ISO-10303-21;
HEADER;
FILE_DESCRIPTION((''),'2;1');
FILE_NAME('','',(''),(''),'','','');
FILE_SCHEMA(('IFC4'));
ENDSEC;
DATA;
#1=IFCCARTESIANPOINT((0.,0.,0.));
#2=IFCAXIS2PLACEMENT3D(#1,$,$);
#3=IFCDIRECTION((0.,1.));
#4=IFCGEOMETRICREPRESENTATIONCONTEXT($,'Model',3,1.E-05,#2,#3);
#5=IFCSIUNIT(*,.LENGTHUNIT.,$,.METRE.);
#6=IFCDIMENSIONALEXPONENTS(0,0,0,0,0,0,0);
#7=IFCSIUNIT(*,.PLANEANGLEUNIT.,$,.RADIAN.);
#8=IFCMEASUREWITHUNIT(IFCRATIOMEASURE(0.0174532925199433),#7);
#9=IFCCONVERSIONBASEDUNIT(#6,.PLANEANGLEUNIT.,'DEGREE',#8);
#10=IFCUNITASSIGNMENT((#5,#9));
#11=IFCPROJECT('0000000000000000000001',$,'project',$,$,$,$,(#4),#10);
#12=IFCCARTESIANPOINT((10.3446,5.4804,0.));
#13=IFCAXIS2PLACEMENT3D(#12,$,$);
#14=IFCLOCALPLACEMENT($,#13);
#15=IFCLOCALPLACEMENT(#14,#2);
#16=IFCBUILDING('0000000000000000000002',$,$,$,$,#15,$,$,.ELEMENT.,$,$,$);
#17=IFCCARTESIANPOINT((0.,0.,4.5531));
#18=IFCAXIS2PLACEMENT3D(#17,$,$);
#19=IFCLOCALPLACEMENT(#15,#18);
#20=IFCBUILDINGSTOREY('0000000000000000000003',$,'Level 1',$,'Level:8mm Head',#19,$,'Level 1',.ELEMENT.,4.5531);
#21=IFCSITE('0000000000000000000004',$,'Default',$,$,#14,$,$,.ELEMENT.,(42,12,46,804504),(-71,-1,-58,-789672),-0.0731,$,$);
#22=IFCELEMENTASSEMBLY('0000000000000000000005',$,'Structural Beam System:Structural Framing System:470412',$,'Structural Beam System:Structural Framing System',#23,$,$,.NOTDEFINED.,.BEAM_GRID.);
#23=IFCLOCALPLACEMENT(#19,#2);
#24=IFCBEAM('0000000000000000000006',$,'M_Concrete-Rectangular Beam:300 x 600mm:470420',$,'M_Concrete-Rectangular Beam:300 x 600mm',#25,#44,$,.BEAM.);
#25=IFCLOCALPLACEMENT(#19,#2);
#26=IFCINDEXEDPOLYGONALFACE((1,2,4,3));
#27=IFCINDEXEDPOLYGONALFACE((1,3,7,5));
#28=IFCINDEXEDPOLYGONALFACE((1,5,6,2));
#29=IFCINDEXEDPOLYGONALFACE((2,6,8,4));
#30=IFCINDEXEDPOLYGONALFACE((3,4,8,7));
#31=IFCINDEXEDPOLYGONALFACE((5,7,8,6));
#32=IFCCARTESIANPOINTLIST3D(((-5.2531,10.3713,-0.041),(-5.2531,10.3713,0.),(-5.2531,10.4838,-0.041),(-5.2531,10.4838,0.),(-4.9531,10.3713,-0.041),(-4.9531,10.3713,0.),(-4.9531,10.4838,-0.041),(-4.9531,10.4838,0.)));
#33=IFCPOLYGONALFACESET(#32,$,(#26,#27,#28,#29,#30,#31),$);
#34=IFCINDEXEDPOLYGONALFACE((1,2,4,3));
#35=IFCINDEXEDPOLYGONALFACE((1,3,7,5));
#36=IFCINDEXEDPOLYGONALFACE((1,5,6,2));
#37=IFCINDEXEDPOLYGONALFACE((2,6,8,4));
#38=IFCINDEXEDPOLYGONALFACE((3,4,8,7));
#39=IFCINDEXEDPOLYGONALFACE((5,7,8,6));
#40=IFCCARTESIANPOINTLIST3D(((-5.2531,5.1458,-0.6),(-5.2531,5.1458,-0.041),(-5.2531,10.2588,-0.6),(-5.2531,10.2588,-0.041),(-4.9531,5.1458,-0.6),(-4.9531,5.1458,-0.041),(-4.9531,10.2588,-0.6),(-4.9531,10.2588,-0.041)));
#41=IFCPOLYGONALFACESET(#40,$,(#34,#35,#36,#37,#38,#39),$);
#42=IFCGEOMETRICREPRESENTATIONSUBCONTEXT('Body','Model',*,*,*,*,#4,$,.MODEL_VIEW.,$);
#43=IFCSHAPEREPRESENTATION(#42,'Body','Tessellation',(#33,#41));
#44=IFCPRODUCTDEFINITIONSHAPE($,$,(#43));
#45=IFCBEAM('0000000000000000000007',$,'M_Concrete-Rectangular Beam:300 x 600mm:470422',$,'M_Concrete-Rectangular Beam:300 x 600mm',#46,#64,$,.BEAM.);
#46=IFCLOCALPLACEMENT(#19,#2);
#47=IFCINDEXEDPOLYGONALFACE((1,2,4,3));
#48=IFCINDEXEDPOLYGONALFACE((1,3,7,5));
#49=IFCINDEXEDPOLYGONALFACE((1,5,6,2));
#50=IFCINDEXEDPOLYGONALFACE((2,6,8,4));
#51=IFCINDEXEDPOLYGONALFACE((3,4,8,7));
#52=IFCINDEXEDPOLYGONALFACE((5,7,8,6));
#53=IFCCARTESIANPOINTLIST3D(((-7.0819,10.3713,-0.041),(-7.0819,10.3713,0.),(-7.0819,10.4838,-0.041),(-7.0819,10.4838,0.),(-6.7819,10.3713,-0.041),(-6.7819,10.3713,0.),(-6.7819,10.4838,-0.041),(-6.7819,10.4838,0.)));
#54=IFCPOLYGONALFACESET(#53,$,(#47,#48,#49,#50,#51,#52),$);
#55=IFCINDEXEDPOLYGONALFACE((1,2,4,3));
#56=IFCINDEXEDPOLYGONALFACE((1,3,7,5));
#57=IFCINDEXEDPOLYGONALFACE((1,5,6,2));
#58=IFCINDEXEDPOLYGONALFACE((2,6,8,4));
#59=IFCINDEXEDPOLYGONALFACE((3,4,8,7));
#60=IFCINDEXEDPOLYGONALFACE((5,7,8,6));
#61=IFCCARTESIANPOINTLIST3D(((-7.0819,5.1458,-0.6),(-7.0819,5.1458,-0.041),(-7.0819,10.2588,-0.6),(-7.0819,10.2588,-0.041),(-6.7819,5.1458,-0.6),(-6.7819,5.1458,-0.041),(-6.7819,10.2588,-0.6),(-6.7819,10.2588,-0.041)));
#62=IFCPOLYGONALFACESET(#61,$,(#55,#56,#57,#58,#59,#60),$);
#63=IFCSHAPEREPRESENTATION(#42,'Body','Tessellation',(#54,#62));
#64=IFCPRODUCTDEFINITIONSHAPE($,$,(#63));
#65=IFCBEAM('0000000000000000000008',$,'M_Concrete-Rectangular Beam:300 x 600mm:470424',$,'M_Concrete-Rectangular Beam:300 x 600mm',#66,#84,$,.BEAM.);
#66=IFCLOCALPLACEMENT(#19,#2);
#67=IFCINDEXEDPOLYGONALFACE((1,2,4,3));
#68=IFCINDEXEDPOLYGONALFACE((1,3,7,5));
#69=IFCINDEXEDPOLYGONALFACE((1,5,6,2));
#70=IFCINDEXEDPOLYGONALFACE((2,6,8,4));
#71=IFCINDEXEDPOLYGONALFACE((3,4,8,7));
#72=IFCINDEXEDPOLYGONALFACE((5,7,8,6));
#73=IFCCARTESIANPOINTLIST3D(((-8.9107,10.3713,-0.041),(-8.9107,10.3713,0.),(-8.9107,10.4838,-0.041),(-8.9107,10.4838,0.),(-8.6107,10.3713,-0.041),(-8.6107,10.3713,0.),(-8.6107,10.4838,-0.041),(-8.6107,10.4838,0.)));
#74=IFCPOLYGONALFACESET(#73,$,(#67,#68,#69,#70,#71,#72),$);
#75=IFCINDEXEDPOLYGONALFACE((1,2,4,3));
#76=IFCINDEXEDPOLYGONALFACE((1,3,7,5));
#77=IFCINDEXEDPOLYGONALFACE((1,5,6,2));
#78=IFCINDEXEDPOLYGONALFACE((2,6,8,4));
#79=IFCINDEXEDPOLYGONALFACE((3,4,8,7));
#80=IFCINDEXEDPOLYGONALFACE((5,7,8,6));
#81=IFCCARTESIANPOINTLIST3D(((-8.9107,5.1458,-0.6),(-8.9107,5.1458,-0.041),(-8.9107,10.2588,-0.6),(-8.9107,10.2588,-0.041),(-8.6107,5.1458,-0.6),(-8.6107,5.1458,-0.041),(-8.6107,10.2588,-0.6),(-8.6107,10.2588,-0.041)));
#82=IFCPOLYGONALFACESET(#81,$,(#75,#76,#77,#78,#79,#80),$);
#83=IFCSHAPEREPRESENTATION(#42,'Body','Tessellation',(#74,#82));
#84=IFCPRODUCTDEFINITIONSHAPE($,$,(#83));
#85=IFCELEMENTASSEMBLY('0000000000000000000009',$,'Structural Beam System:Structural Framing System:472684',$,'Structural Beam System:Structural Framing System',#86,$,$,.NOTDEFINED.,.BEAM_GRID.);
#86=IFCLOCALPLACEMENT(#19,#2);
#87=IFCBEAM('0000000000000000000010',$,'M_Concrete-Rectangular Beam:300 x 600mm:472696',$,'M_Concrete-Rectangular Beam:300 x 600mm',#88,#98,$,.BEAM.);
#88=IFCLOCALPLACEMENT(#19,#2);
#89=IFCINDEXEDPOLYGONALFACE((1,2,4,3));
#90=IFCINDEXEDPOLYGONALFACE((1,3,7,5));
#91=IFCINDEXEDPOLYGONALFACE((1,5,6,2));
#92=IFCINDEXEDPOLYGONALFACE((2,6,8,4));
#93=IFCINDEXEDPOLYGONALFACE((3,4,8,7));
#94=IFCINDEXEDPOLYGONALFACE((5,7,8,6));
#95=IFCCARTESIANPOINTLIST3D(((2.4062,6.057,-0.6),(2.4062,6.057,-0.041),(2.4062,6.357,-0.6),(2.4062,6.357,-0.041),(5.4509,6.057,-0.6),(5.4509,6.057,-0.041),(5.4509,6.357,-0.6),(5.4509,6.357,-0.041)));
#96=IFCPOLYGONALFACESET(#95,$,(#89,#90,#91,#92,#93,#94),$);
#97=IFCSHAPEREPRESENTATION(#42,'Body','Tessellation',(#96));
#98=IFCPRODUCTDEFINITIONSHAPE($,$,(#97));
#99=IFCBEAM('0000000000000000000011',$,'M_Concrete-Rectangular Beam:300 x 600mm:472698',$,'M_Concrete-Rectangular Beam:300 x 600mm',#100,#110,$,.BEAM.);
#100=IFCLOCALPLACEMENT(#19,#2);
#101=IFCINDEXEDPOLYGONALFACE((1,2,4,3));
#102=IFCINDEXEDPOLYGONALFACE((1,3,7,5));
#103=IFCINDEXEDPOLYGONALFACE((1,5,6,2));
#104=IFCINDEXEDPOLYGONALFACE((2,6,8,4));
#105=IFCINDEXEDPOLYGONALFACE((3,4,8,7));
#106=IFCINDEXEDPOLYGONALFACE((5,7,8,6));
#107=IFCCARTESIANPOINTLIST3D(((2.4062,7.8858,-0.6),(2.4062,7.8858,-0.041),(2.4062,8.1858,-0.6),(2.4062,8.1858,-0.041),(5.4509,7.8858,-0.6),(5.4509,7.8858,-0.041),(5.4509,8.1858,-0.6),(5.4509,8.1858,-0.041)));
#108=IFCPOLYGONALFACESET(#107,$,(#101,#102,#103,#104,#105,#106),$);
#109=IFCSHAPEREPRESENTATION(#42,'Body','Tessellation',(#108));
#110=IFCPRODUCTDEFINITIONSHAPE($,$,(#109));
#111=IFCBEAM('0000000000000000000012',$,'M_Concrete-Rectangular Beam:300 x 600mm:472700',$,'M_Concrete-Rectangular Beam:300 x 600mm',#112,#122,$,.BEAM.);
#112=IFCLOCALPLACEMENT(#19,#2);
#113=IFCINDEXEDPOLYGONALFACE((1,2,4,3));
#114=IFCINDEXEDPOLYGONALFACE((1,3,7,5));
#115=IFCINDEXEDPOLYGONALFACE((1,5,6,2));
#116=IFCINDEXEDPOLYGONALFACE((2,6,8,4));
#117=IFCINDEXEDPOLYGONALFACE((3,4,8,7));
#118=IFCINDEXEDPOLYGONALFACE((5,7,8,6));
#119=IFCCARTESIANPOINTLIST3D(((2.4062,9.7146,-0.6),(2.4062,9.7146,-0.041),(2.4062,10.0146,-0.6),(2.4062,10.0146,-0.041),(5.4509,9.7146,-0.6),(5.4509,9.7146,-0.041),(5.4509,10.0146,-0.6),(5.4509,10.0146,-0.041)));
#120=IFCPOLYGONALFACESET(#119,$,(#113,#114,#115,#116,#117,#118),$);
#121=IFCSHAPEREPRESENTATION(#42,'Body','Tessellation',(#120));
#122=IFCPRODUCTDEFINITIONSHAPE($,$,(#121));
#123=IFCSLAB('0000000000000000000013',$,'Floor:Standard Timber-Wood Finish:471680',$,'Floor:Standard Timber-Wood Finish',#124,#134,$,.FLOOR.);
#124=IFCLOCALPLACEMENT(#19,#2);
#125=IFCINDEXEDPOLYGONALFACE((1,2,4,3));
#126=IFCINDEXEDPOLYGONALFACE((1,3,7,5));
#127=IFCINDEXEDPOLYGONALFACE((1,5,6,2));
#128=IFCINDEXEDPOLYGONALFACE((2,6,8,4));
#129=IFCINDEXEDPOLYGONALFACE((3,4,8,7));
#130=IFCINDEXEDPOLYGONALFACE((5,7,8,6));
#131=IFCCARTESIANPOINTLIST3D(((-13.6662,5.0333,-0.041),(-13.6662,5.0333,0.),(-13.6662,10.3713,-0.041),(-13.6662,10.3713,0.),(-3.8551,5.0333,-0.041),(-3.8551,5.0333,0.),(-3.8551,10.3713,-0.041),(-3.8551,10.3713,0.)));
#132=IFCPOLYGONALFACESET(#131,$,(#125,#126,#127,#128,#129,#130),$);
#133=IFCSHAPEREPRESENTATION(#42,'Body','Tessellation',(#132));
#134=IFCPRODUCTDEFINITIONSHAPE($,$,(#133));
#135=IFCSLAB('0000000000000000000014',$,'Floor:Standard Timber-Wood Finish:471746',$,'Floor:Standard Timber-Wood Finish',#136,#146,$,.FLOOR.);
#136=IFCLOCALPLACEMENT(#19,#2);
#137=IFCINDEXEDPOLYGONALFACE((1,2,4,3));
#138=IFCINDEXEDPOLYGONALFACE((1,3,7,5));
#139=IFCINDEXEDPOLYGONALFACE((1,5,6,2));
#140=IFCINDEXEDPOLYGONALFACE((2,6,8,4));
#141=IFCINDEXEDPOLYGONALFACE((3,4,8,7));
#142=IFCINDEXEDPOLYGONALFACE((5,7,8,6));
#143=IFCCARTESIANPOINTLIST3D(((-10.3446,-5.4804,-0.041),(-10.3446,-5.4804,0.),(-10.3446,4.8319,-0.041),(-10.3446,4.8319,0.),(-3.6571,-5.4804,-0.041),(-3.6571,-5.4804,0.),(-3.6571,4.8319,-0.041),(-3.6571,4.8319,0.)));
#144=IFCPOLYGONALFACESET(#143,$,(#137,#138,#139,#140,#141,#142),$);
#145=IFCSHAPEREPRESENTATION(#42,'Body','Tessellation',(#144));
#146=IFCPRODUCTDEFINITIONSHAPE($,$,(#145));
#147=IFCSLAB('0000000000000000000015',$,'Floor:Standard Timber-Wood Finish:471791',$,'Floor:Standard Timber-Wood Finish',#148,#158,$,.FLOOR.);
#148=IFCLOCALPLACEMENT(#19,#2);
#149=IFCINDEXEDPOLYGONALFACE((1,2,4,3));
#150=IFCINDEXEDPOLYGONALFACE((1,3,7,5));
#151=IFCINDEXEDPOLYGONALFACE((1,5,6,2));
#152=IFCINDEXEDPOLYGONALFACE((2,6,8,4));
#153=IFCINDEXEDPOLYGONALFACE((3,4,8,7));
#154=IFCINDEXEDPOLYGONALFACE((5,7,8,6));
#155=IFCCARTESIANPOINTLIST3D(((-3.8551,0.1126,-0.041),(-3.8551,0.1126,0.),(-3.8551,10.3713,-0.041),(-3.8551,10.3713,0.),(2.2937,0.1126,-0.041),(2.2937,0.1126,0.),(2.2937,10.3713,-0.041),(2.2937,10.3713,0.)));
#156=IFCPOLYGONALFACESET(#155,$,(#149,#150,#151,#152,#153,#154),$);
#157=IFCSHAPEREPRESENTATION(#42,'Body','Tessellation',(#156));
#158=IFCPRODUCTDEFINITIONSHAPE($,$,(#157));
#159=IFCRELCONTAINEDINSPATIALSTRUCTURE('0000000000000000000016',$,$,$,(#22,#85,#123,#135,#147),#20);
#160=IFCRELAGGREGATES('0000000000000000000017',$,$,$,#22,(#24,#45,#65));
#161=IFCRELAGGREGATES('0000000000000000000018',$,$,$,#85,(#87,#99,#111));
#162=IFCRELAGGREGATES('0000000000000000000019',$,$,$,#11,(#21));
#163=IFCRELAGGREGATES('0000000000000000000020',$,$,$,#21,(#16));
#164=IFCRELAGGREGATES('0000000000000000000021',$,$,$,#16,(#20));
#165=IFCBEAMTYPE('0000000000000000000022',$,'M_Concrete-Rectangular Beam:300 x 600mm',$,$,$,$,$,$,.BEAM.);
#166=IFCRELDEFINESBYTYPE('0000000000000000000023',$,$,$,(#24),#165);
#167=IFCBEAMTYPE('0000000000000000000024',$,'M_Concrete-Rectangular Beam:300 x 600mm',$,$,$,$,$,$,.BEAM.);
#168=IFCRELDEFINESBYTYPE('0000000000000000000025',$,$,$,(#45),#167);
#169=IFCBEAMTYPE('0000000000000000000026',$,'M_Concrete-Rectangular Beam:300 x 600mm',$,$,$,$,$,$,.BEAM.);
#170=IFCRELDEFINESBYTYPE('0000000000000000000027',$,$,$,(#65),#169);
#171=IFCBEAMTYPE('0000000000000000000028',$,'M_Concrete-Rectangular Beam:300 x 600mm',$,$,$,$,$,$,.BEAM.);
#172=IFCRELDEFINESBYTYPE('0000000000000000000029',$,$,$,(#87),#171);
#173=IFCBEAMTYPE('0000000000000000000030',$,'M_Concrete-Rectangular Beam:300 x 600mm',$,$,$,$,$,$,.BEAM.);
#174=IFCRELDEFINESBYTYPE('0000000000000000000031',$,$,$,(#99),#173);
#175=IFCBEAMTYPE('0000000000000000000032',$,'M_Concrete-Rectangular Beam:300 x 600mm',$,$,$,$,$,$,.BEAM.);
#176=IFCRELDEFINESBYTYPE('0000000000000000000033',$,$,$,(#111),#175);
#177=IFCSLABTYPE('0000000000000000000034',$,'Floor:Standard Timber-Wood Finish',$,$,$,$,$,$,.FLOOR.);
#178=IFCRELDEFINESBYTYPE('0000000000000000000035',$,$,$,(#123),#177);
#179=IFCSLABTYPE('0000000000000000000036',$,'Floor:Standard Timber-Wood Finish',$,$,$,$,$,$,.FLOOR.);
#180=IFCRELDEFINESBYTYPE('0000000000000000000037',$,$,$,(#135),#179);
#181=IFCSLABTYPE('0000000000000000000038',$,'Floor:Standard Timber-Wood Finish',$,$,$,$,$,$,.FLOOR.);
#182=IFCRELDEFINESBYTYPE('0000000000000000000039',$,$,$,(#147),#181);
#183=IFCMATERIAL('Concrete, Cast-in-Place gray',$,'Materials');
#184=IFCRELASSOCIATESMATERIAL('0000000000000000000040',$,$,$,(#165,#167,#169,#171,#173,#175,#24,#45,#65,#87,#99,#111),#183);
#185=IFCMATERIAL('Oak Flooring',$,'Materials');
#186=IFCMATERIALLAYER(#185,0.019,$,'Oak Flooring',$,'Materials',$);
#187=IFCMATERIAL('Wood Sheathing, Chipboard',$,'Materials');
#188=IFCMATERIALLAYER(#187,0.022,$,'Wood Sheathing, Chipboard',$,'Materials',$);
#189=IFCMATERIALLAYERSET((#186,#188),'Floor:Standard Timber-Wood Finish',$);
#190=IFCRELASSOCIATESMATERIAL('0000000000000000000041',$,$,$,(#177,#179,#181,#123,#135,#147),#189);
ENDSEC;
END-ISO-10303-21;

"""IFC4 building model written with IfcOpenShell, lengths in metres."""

from ifc_helpers import new_model, entity, si_unit, converted_unit, direction, frame, frame_2d, origin, origin_2d_with_axis, place, context, subcontext, project, spatial, rectangle, extrude, source, transform, mapped, material, layer, layer_set, layer_usage, material_profile, profile_set, profile_usage, type_object, type_shapes, element, aggregate, save


model = new_model("IFC4")

# Units and contexts
model_context = context("Model", 3, precision=1e-05, world=origin(), true_north=direction((0.0, 1.0)))
body_context = subcontext(model_context, "Body", "Model", "MODEL_VIEW")
ifc_project = project(units=[si_unit("LENGTHUNIT", "METRE"), converted_unit("PLANEANGLEUNIT", "DEGREE", entity("IfcRatioMeasure", 0.0174532925199433), si_unit("PLANEANGLEUNIT", "RADIAN"), dimensions=[0, 0, 0, 0, 0, 0, 0])], contexts=[model_context])

# Site, building, storey
site_placement = place(None, frame((10.3446, 5.4804, 0.0)))
site = spatial("IfcSite", under=ifc_project, at=site_placement, Name="Default", CompositionType="ELEMENT", RefLatitude=(42, 12, 46, 804504), RefLongitude=(-71, -1, -58, -789672), RefElevation=-0.0731)
building_placement = place(site_placement, origin())
building = spatial("IfcBuilding", under=site, at=building_placement, CompositionType="ELEMENT")
storey_placement = place(building_placement, frame((0.0, 0.0, 4.5531)))
storey = spatial("IfcBuildingStorey", under=building, at=storey_placement, Name="Level 1", ObjectType="Level:8mm Head", LongName="Level 1", CompositionType="ELEMENT", Elevation=4.5531)

# Element assemblies, beams
assembly_1_placement = place(storey_placement, origin())
assembly_1 = element("IfcElementAssembly", 1, at=assembly_1_placement, inside=storey, Name="Structural Beam System:Structural Framing System:470412", ObjectType="Structural Beam System:Structural Framing System", AssemblyPlace="NOTDEFINED", PredefinedType="BEAM_GRID")
ifc_material_1 = material(Name="Concrete, Cast-in-Place gray", Category="Materials")
ifc_material_profile = material_profile(ifc_material_1, rectangle(XDim=0.559, YDim=0.3, at=frame_2d((0.0, 0.0), x_axis=(1.0, 0.0))), Name="300 x 600mm")
ifc_profile_set = profile_set([ifc_material_profile], Name="300 x 600mm")
ifc_profile_usage_1 = profile_usage(ifc_profile_set, cardinal=8)
beam_type_1 = type_object("IfcBeamType", Name="M_Concrete-Rectangular Beam:300 x 600mm", PredefinedType="BEAM", material=ifc_profile_set)
shared_shape_1 = source(origin(), body_context, "Body", "SweptSolid", [
    extrude(rectangle(XDim=0.041, YDim=0.3, at=frame_2d((0.0, 0.0), x_axis=(0.0, 1.0))), frame((-5.1031, 10.4838, 4.5326), z_axis=(0.0, -1.0, 0.0), x_axis=(-1.0, 0.0, 0.0)), (0.0, 0.0, 1.0), 0.1125),
    extrude(rectangle(XDim=0.559, YDim=0.3, at=frame_2d((0.0, 0.0), x_axis=(0.0, 1.0))), frame((-5.1031, 10.2588, 4.2326), z_axis=(0.0, -1.0, 0.0), x_axis=(-1.0, 0.0, 0.0)), (0.0, 0.0, 1.0), 5.113),
])
type_shapes(beam_type_1, [shared_shape_1])
beam_1_placement = place(assembly_1_placement, frame((0.0, 0.0, -4.5531)))
beam_1 = element("IfcBeam", 2, at=beam_1_placement, type_object=beam_type_1, material=ifc_profile_usage_1, Name="M_Concrete-Rectangular Beam:300 x 600mm:470420", ObjectType="M_Concrete-Rectangular Beam:300 x 600mm", PredefinedType="BEAM", context=body_context, shape_type="MappedRepresentation", body=[
    mapped(shared_shape_1, transform((0.0, 0.0, 0.0), scale=1.0)),
])
ifc_profile_usage_2 = profile_usage(ifc_profile_set, cardinal=8)
beam_type_2 = type_object("IfcBeamType", Name="M_Concrete-Rectangular Beam:300 x 600mm", PredefinedType="BEAM", material=ifc_profile_set)
shared_shape_2 = source(origin(), body_context, "Body", "SweptSolid", [
    extrude(rectangle(XDim=0.041, YDim=0.3, at=frame_2d((0.0, 0.0), x_axis=(0.0, 1.0))), frame((-6.9319, 10.4838, 4.5326), z_axis=(0.0, -1.0, 0.0), x_axis=(-1.0, 0.0, 0.0)), (0.0, 0.0, 1.0), 0.1125),
    extrude(rectangle(XDim=0.559, YDim=0.3, at=frame_2d((0.0, 0.0), x_axis=(0.0, 1.0))), frame((-6.9319, 10.2588, 4.2326), z_axis=(0.0, -1.0, 0.0), x_axis=(-1.0, 0.0, 0.0)), (0.0, 0.0, 1.0), 5.113),
])
type_shapes(beam_type_2, [shared_shape_2])
beam_2_placement = place(assembly_1_placement, frame((0.0, 0.0, -4.5531)))
beam_2 = element("IfcBeam", 3, at=beam_2_placement, type_object=beam_type_2, material=ifc_profile_usage_2, Name="M_Concrete-Rectangular Beam:300 x 600mm:470422", ObjectType="M_Concrete-Rectangular Beam:300 x 600mm", PredefinedType="BEAM", context=body_context, shape_type="MappedRepresentation", body=[
    mapped(shared_shape_2, transform((0.0, 0.0, 0.0), scale=1.0)),
])
ifc_profile_usage_3 = profile_usage(ifc_profile_set, cardinal=8)
beam_type_3 = type_object("IfcBeamType", Name="M_Concrete-Rectangular Beam:300 x 600mm", PredefinedType="BEAM", material=ifc_profile_set)
shared_shape_3 = source(origin(), body_context, "Body", "SweptSolid", [
    extrude(rectangle(XDim=0.041, YDim=0.3, at=frame_2d((0.0, 0.0), x_axis=(0.0, 1.0))), frame((-8.7607, 10.4838, 4.5326), z_axis=(0.0, -1.0, 0.0), x_axis=(-1.0, 0.0, 0.0)), (0.0, 0.0, 1.0), 0.1125),
    extrude(rectangle(XDim=0.559, YDim=0.3, at=frame_2d((0.0, 0.0), x_axis=(0.0, 1.0))), frame((-8.7607, 10.2588, 4.2326), z_axis=(0.0, -1.0, 0.0), x_axis=(-1.0, 0.0, 0.0)), (0.0, 0.0, 1.0), 5.113),
])
type_shapes(beam_type_3, [shared_shape_3])
beam_3_placement = place(assembly_1_placement, frame((0.0, 0.0, -4.5531)))
beam_3 = element("IfcBeam", 4, at=beam_3_placement, type_object=beam_type_3, material=ifc_profile_usage_3, Name="M_Concrete-Rectangular Beam:300 x 600mm:470424", ObjectType="M_Concrete-Rectangular Beam:300 x 600mm", PredefinedType="BEAM", context=body_context, shape_type="MappedRepresentation", body=[
    mapped(shared_shape_3, transform((0.0, 0.0, 0.0), scale=1.0)),
])
aggregate(assembly_1, [beam_1, beam_2, beam_3])
assembly_2_placement = place(storey_placement, origin())
assembly_2 = element("IfcElementAssembly", 5, at=assembly_2_placement, inside=storey, Name="Structural Beam System:Structural Framing System:472684", ObjectType="Structural Beam System:Structural Framing System", AssemblyPlace="NOTDEFINED", PredefinedType="BEAM_GRID")
ifc_profile_usage_4 = profile_usage(ifc_profile_set, cardinal=8)
beam_type_4 = type_object("IfcBeamType", Name="M_Concrete-Rectangular Beam:300 x 600mm", PredefinedType="BEAM", material=ifc_profile_set)
shared_shape_4 = source(origin(), body_context, "Body", "SweptSolid", [
    extrude(rectangle(XDim=0.559, YDim=0.3, at=frame_2d((0.0, 0.0), x_axis=(1.0, 0.0))), frame((5.4509, 6.207, 4.2326), z_axis=(-1.0, 0.0, 0.0), x_axis=(0.0, 0.0, -1.0)), (0.0, 0.0, 1.0), 3.0447),
])
type_shapes(beam_type_4, [shared_shape_4])
beam_4_placement = place(assembly_2_placement, frame((0.0, 0.0, -4.5531)))
beam_4 = element("IfcBeam", 6, at=beam_4_placement, type_object=beam_type_4, material=ifc_profile_usage_4, Name="M_Concrete-Rectangular Beam:300 x 600mm:472696", ObjectType="M_Concrete-Rectangular Beam:300 x 600mm", PredefinedType="BEAM", context=body_context, shape_type="MappedRepresentation", body=[
    mapped(shared_shape_4, transform((0.0, 0.0, 0.0), scale=1.0)),
])
ifc_profile_usage_5 = profile_usage(ifc_profile_set, cardinal=8)
beam_type_5 = type_object("IfcBeamType", Name="M_Concrete-Rectangular Beam:300 x 600mm", PredefinedType="BEAM", material=ifc_profile_set)
shared_shape_5 = source(origin(), body_context, "Body", "SweptSolid", [
    extrude(rectangle(XDim=0.559, YDim=0.3, at=frame_2d((0.0, 0.0), x_axis=(1.0, 0.0))), frame((5.4509, 8.0358, 4.2326), z_axis=(-1.0, 0.0, 0.0), x_axis=(0.0, 0.0, -1.0)), (0.0, 0.0, 1.0), 3.0447),
])
type_shapes(beam_type_5, [shared_shape_5])
beam_5_placement = place(assembly_2_placement, frame((0.0, 0.0, -4.5531)))
beam_5 = element("IfcBeam", 7, at=beam_5_placement, type_object=beam_type_5, material=ifc_profile_usage_5, Name="M_Concrete-Rectangular Beam:300 x 600mm:472698", ObjectType="M_Concrete-Rectangular Beam:300 x 600mm", PredefinedType="BEAM", context=body_context, shape_type="MappedRepresentation", body=[
    mapped(shared_shape_5, transform((0.0, 0.0, 0.0), scale=1.0)),
])
ifc_profile_usage_6 = profile_usage(ifc_profile_set, cardinal=8)
beam_type_6 = type_object("IfcBeamType", Name="M_Concrete-Rectangular Beam:300 x 600mm", PredefinedType="BEAM", material=ifc_profile_set)
shared_shape_6 = source(origin(), body_context, "Body", "SweptSolid", [
    extrude(rectangle(XDim=0.559, YDim=0.3, at=frame_2d((0.0, 0.0), x_axis=(1.0, 0.0))), frame((5.4509, 9.8646, 4.2326), z_axis=(-1.0, 0.0, 0.0), x_axis=(0.0, 0.0, -1.0)), (0.0, 0.0, 1.0), 3.0447),
])
type_shapes(beam_type_6, [shared_shape_6])
beam_6_placement = place(assembly_2_placement, frame((0.0, 0.0, -4.5531)))
beam_6 = element("IfcBeam", 8, at=beam_6_placement, type_object=beam_type_6, material=ifc_profile_usage_6, Name="M_Concrete-Rectangular Beam:300 x 600mm:472700", ObjectType="M_Concrete-Rectangular Beam:300 x 600mm", PredefinedType="BEAM", context=body_context, shape_type="MappedRepresentation", body=[
    mapped(shared_shape_6, transform((0.0, 0.0, 0.0), scale=1.0)),
])
aggregate(assembly_2, [beam_4, beam_5, beam_6])

# Slabs
ifc_material_2 = material(Name="Oak Flooring", Category="Materials")
ifc_layer_1 = layer(ifc_material_2, 0.019, Name="Oak Flooring", Category="Materials")
ifc_material_3 = material(Name="Wood Sheathing, Chipboard", Category="Materials")
ifc_layer_2 = layer(ifc_material_3, 0.022, Name="Wood Sheathing, Chipboard", Category="Materials")
ifc_layer_set_1 = layer_set([ifc_layer_1, ifc_layer_2], Name="Floor:Standard Timber-Wood Finish")
ifc_layer_usage_1 = layer_usage(ifc_layer_set_1, "AXIS3", "POSITIVE", 0.0)
slab_type_1 = type_object("IfcSlabType", Name="Floor:Standard Timber-Wood Finish", PredefinedType="FLOOR", material=ifc_layer_set_1)
slab_1_placement = place(storey_placement, origin())
element("IfcSlab", 9, at=slab_1_placement, inside=storey, type_object=slab_type_1, material=ifc_layer_usage_1, Name="Floor:Standard Timber-Wood Finish:471680", ObjectType="Floor:Standard Timber-Wood Finish", PredefinedType="FLOOR", context=body_context, shape_type="SweptSolid", body=[
    extrude(rectangle(XDim=5.338, YDim=9.8111, at=frame_2d((0.0, 0.0), x_axis=(1.0, 0.0))), frame((-8.7607, 7.7023, 0.0), z_axis=(0.0, 0.0, -1.0), x_axis=(0.0, 1.0, 0.0)), (0.0, 0.0, 1.0), 0.041),
])
ifc_layer_usage_2 = layer_usage(ifc_layer_set_1, "AXIS3", "POSITIVE", 0.0)
slab_type_2 = type_object("IfcSlabType", Name="Floor:Standard Timber-Wood Finish", PredefinedType="FLOOR", material=ifc_layer_set_1)
slab_2_placement = place(storey_placement, origin())
element("IfcSlab", 10, at=slab_2_placement, inside=storey, type_object=slab_type_2, material=ifc_layer_usage_2, Name="Floor:Standard Timber-Wood Finish:471746", ObjectType="Floor:Standard Timber-Wood Finish", PredefinedType="FLOOR", context=body_context, shape_type="SweptSolid", body=[
    extrude(rectangle(XDim=10.3123, YDim=6.6875, at=frame_2d((0.0, 0.0), x_axis=(1.0, 0.0))), frame((-7.0009, -0.3243, 0.0), z_axis=(0.0, 0.0, -1.0), x_axis=(0.0, 1.0, 0.0)), (0.0, 0.0, 1.0), 0.041),
])
ifc_layer_usage_3 = layer_usage(ifc_layer_set_1, "AXIS3", "POSITIVE", 0.0)
slab_type_3 = type_object("IfcSlabType", Name="Floor:Standard Timber-Wood Finish", PredefinedType="FLOOR", material=ifc_layer_set_1)
slab_3_placement = place(storey_placement, origin())
element("IfcSlab", 11, at=slab_3_placement, inside=storey, type_object=slab_type_3, material=ifc_layer_usage_3, Name="Floor:Standard Timber-Wood Finish:471791", ObjectType="Floor:Standard Timber-Wood Finish", PredefinedType="FLOOR", context=body_context, shape_type="SweptSolid", body=[
    extrude(rectangle(XDim=10.2587, YDim=6.1488, at=origin_2d_with_axis()), frame((-0.7807, 5.2419, 0.0), z_axis=(0.0, 0.0, -1.0), x_axis=(0.0, 1.0, 0.0)), (0.0, 0.0, 1.0), 0.041),
])

save(model, "model.ifc")
